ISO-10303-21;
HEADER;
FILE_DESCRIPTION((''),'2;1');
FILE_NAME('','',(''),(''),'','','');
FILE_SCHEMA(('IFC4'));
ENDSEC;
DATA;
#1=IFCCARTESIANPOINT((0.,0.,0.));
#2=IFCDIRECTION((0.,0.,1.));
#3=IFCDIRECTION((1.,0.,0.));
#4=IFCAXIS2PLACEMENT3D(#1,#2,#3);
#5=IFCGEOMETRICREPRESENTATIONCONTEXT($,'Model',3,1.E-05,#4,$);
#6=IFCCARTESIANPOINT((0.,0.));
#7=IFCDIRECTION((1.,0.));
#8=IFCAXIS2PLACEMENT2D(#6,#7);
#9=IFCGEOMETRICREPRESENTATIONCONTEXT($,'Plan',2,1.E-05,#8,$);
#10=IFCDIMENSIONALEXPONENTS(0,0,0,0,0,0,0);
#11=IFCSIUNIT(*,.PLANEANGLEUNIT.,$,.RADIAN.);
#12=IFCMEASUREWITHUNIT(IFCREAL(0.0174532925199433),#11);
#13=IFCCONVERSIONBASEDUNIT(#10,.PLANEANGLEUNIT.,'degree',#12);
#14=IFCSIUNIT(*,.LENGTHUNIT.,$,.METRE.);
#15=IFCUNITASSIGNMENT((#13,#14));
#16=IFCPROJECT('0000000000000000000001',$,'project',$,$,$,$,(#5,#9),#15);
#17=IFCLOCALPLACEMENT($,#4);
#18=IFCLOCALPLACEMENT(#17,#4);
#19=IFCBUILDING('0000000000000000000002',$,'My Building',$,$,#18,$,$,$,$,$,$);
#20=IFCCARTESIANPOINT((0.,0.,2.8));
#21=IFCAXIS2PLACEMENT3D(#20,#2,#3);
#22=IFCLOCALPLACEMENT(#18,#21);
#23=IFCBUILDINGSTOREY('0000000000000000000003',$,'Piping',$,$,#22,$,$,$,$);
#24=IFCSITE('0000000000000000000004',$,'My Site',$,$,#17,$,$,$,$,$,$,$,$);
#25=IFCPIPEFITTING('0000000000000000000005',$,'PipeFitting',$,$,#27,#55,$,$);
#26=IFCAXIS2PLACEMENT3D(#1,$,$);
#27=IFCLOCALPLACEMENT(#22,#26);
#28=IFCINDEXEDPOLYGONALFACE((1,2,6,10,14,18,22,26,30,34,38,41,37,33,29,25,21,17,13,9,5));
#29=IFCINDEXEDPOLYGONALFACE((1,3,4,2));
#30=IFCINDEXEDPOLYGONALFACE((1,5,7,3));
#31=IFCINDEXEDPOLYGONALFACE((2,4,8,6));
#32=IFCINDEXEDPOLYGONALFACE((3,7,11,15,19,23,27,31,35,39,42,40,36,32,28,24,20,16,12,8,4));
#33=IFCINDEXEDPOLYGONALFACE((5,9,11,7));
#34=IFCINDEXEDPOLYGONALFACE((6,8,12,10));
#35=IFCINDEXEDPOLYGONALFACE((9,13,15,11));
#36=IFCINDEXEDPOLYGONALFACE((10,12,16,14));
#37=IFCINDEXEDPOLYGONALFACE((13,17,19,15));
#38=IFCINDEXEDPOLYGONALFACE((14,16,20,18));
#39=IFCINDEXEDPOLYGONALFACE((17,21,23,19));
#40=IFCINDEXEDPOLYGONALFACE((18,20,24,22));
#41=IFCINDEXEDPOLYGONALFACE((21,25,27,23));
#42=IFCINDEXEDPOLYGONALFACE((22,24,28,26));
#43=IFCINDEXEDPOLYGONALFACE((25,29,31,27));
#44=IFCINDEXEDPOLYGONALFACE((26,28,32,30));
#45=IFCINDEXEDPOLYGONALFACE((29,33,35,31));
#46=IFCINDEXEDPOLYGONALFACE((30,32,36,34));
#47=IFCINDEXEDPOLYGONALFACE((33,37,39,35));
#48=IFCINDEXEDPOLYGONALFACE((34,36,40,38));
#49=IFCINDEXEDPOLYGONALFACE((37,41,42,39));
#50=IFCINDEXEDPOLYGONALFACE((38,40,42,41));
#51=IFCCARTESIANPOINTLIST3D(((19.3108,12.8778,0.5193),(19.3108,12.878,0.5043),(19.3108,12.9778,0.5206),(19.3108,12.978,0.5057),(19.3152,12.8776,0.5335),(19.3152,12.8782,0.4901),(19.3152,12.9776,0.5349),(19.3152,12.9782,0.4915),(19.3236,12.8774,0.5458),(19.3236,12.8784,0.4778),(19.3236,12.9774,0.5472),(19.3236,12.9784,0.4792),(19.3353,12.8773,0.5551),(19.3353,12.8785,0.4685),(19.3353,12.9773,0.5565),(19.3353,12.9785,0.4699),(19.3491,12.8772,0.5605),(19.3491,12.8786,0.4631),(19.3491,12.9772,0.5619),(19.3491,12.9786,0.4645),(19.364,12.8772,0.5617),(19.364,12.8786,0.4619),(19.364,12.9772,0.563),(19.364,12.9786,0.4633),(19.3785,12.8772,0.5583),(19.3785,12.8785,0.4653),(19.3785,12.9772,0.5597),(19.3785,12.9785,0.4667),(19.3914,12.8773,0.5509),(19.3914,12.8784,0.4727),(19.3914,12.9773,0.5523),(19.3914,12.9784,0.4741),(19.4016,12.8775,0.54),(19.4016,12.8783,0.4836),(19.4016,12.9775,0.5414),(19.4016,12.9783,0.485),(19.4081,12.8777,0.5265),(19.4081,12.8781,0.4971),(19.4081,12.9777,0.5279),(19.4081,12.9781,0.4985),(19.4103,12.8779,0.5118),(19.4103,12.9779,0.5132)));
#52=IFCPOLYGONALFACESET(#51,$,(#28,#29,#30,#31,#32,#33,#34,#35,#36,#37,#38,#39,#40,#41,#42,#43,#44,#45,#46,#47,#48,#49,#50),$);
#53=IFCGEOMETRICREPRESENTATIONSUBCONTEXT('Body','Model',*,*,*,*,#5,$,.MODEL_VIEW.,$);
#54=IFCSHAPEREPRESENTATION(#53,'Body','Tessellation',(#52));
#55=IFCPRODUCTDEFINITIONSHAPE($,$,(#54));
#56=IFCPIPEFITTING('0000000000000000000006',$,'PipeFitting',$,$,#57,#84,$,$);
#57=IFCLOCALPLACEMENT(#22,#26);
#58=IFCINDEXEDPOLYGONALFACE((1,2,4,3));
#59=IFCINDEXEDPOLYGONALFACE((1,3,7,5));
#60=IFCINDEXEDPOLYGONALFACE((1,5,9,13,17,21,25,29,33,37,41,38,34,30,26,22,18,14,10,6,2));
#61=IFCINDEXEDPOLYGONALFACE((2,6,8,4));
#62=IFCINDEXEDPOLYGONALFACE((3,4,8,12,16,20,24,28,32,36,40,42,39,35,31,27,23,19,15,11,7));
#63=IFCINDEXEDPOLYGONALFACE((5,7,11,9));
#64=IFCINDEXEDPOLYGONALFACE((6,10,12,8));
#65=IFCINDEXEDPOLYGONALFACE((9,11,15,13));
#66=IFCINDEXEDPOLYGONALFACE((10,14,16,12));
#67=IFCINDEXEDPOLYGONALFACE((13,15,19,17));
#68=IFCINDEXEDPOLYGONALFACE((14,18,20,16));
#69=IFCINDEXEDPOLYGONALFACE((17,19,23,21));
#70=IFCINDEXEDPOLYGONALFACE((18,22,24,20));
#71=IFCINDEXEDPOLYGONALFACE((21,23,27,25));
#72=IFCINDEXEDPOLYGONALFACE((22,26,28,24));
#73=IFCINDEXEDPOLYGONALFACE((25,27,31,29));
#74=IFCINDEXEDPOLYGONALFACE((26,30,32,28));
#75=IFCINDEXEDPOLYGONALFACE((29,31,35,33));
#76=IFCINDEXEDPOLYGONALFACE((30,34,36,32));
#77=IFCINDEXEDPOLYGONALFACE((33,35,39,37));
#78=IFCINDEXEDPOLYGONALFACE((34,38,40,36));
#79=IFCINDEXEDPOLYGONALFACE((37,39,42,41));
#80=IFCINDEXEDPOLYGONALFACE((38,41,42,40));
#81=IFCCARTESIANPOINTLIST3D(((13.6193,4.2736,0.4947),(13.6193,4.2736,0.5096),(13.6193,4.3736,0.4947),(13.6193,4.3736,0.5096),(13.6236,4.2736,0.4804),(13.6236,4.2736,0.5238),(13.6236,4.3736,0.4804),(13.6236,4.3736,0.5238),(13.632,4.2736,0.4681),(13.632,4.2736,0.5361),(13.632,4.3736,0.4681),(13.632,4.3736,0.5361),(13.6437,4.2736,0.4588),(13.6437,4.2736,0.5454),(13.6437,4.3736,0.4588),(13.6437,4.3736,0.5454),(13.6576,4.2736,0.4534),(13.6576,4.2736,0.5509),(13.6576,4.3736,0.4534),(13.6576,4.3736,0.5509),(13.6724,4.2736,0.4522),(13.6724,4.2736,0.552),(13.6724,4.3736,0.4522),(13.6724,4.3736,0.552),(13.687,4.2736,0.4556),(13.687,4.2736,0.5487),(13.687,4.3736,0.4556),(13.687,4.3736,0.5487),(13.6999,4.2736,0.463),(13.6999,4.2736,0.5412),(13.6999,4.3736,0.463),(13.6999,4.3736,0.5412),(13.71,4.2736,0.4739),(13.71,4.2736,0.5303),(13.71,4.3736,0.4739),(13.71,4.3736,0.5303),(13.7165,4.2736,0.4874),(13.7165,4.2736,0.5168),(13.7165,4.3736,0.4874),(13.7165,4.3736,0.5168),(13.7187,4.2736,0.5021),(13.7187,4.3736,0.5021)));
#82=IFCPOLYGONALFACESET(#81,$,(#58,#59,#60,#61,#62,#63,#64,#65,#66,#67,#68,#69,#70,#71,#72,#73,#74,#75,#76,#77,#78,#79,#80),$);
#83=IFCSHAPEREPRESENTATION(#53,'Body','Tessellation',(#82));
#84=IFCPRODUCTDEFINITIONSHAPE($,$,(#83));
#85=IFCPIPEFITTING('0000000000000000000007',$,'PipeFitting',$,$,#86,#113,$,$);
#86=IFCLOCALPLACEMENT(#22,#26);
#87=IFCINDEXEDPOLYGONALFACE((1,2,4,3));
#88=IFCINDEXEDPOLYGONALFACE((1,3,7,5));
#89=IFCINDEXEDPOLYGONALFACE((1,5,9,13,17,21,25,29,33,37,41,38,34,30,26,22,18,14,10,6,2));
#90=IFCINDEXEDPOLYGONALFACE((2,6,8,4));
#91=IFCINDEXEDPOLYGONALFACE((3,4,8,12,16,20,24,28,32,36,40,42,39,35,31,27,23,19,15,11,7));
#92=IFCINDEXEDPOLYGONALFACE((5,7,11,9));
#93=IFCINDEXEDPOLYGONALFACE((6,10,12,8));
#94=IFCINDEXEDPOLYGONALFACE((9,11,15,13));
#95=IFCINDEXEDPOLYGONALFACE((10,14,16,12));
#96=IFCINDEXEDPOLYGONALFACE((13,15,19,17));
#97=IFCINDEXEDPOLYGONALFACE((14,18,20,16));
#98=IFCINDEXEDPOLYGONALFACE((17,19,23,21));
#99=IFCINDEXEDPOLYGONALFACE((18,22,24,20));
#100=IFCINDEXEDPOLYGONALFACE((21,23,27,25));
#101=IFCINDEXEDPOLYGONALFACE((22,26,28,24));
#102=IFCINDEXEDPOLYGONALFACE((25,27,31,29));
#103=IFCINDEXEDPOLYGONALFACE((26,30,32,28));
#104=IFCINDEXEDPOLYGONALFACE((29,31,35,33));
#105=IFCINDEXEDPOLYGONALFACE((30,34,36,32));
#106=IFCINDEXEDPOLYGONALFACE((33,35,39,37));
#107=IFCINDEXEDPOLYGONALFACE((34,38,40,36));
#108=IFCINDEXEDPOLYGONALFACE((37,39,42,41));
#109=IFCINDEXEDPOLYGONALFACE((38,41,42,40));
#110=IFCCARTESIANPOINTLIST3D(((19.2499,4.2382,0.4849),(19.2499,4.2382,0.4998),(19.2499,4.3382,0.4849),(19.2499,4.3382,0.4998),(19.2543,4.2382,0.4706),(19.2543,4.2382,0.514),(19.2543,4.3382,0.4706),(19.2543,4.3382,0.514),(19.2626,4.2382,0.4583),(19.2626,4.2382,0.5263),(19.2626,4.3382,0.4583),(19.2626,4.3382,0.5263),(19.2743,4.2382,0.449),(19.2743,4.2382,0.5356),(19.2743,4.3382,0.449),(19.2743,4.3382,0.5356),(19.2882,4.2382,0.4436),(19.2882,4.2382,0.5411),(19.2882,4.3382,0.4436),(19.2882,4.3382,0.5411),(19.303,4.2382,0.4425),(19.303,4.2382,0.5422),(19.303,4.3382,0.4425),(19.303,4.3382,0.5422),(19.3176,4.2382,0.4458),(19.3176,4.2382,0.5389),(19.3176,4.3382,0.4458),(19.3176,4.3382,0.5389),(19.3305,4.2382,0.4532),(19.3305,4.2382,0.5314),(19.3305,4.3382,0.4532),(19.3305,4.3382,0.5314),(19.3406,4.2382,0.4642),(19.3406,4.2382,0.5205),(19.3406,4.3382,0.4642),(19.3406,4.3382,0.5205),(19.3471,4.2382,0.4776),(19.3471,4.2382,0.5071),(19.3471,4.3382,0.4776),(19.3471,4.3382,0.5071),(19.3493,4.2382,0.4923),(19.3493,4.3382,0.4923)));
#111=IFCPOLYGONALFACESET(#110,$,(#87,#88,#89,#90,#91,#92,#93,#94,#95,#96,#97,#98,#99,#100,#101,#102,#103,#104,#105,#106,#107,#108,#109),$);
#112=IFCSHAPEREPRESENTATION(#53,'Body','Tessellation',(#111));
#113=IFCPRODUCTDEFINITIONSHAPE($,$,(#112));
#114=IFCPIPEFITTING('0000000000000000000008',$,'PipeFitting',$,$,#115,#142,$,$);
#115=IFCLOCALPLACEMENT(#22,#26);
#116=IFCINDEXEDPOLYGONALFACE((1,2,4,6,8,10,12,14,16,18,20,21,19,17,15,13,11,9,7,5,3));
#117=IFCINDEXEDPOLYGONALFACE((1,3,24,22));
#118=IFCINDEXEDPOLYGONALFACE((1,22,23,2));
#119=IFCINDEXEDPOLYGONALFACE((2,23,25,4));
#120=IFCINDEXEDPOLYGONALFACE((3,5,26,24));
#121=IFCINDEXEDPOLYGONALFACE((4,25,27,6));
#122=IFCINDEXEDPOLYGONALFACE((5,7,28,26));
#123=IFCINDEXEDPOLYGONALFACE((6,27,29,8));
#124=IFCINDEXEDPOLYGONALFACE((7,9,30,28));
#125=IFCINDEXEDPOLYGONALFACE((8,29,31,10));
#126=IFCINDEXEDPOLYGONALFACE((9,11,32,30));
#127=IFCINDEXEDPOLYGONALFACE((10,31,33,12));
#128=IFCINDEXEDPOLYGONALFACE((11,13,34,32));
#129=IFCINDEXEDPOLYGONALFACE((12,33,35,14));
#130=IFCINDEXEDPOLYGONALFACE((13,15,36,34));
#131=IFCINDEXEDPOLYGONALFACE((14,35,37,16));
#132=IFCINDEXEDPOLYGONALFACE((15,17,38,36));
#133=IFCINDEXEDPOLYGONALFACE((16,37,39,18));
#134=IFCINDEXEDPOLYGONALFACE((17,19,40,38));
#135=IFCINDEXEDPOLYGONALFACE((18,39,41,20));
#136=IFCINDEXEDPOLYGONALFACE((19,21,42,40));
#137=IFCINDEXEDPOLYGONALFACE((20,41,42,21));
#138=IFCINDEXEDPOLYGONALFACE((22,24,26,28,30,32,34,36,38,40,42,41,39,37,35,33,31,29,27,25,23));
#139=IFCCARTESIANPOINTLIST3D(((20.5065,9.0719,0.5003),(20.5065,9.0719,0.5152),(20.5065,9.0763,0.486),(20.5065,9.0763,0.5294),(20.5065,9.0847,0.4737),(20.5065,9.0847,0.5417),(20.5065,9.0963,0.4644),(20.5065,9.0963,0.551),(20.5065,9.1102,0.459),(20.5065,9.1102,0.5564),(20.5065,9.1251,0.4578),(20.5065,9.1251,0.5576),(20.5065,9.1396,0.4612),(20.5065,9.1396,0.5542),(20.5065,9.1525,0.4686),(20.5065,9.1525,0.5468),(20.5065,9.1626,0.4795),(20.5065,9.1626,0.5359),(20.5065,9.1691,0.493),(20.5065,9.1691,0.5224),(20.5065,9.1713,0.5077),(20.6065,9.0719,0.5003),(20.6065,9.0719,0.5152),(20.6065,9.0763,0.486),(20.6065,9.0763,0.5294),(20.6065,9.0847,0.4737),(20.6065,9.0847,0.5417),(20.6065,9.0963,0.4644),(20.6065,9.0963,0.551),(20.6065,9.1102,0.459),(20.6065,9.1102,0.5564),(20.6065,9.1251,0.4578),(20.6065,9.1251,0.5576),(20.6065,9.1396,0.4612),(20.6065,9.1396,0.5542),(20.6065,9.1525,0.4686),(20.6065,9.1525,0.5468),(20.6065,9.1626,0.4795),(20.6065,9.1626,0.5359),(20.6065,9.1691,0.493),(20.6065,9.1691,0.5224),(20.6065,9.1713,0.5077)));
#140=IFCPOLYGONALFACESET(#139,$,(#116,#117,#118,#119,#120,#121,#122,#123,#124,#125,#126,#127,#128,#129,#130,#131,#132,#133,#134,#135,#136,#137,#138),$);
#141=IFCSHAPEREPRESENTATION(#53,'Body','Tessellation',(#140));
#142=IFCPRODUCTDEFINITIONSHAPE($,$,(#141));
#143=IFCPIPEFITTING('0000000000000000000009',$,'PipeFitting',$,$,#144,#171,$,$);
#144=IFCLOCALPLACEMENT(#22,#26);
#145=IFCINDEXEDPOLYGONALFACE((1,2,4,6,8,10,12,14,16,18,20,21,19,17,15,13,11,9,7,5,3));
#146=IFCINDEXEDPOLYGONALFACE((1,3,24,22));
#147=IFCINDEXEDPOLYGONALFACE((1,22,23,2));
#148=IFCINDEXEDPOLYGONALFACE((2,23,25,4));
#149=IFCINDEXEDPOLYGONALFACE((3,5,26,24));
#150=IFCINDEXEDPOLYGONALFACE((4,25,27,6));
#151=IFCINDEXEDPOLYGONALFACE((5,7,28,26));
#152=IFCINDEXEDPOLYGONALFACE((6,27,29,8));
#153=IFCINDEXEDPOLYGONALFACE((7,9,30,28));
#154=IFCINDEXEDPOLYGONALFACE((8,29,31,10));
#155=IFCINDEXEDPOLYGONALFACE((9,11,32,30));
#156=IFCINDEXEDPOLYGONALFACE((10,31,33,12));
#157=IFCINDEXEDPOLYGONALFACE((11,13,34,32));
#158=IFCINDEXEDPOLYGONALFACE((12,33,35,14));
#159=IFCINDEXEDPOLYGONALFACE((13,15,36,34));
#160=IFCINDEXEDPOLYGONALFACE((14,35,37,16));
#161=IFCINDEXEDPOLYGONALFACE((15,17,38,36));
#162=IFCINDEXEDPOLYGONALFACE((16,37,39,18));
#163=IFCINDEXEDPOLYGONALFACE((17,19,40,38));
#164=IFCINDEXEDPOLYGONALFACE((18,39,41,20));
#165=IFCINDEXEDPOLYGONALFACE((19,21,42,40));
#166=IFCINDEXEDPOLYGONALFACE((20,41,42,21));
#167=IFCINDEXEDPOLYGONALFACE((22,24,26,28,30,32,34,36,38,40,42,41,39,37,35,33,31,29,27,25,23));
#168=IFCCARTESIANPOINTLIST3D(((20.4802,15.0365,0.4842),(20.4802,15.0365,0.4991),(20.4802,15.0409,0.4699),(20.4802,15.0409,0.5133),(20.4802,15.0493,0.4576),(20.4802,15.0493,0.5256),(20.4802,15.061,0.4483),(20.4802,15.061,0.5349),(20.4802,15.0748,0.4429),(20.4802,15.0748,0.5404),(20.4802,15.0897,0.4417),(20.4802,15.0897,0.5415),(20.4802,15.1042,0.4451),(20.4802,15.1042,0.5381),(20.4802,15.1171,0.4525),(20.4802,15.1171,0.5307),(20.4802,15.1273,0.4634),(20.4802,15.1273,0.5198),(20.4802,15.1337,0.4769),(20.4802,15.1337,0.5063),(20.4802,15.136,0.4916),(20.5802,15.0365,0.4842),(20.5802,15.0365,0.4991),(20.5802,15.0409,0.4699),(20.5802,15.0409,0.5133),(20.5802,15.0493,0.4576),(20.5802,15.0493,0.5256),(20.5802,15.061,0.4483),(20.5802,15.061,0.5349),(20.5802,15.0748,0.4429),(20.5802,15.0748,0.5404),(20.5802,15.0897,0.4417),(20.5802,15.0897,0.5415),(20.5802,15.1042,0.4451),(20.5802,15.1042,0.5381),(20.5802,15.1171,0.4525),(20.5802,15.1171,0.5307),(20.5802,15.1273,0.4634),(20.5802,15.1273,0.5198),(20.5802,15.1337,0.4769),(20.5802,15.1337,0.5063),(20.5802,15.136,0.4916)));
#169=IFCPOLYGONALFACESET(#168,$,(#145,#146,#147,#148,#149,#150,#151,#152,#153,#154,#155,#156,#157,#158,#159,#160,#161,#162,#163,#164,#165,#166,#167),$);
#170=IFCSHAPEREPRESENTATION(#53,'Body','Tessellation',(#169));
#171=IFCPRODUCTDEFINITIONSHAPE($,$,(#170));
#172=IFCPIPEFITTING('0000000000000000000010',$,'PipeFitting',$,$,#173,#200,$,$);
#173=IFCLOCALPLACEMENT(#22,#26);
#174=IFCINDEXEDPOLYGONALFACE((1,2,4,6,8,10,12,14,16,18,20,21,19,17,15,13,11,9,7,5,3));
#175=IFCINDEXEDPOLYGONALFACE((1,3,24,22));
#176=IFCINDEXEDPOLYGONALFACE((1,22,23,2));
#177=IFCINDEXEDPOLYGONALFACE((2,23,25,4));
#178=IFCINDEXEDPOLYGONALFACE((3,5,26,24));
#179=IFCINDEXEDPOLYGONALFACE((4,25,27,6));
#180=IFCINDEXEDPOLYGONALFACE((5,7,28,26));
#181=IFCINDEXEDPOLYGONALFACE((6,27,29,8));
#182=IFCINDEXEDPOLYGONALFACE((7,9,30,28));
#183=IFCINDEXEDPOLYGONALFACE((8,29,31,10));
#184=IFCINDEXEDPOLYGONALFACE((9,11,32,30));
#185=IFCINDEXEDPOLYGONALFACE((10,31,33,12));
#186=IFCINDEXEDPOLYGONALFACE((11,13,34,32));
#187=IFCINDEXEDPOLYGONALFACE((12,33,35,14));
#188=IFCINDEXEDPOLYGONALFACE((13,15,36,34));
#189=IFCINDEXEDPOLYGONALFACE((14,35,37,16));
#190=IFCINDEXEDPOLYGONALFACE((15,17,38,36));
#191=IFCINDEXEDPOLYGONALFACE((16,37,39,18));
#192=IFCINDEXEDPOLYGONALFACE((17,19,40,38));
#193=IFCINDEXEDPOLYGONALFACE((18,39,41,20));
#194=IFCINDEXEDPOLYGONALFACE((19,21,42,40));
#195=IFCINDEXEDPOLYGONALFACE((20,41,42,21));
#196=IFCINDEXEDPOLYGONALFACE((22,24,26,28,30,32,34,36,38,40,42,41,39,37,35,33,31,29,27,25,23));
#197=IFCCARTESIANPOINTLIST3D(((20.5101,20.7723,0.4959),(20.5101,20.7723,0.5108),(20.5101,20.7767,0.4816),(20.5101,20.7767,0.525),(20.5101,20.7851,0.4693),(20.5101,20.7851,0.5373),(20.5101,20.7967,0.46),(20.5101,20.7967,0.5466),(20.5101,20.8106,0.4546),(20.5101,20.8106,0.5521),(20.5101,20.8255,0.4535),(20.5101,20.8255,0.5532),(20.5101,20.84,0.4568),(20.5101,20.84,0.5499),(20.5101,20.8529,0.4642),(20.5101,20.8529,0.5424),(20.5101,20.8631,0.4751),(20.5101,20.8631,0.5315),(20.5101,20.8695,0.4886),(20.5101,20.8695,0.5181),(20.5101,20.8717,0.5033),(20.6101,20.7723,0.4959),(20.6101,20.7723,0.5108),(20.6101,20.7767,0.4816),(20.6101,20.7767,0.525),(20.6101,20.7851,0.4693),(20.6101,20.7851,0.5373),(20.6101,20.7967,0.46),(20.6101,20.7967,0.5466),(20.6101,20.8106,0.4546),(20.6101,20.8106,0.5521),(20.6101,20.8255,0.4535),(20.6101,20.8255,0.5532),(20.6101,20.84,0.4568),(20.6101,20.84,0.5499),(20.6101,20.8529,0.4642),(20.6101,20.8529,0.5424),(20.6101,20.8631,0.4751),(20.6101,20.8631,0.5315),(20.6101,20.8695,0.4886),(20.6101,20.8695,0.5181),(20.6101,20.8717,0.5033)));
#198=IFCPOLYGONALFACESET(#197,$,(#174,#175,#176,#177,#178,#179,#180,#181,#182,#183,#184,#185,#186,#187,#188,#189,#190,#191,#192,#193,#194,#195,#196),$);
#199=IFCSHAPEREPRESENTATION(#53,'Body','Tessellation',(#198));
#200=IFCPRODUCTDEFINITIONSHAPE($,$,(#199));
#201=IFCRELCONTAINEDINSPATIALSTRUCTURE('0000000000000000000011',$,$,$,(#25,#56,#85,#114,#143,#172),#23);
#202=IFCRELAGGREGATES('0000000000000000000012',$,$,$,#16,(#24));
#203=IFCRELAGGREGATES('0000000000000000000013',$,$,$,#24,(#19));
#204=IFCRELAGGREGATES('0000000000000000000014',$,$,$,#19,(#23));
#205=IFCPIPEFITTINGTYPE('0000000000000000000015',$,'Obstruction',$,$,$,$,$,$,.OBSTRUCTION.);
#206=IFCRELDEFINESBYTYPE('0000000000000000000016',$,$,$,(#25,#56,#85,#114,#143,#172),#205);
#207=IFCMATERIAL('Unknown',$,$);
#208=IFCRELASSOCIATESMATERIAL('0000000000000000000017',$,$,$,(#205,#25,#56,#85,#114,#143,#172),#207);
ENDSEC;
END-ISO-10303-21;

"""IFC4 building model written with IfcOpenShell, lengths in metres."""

from ifc_helpers import new_model, entity, si_unit, converted_unit, frame, origin_with_axes, origin_2d_with_axis, place, context, subcontext, project, spatial, circle, extrude, material, material_profile, profile_set, profile_usage, type_object, element, save


model = new_model("IFC4")

# Units and contexts
model_context = context("Model", 3, precision=1e-05, world=origin_with_axes())
plan_context = context("Plan", 2, precision=1e-05, world=origin_2d_with_axis())
body_context = subcontext(model_context, "Body", "Model", "MODEL_VIEW")
ifc_project = project(units=[converted_unit("PLANEANGLEUNIT", "degree", entity("IfcReal", 0.0174532925199433), si_unit("PLANEANGLEUNIT", "RADIAN"), dimensions=[0, 0, 0, 0, 0, 0, 0]), si_unit("LENGTHUNIT", "METRE")], contexts=[model_context, plan_context])

# Site, building, storey
site_placement = place(None, origin_with_axes())
site = spatial("IfcSite", under=ifc_project, at=site_placement, Name="My Site")
building_placement = place(site_placement, origin_with_axes())
building = spatial("IfcBuilding", under=site, at=building_placement, Name="My Building")
storey_placement = place(building_placement, frame((0.0, 0.0, 2.8), z_axis=(0.0, 0.0, 1.0), x_axis=(1.0, 0.0, 0.0)))
storey = spatial("IfcBuildingStorey", under=building, at=storey_placement, Name="Piping")

# Shared definitions
ifc_material = material(Name="Unknown")

# Pipe fittings
ifc_material_profile_1 = material_profile(ifc_material, circle(Radius=0.05))
ifc_profile_set_1 = profile_set([ifc_material_profile_1])
ifc_profile_usage_1 = profile_usage(ifc_profile_set_1, cardinal=5)
pipe_fitting_type_1 = type_object("IfcPipeFittingType", Name="Obstruction", PredefinedType="OBSTRUCTION", material=ifc_profile_set_1)
pipe_fitting_1_placement = place(storey_placement, frame((19.3603, 12.9779, 0.5132), z_axis=(0.0, -0.999903, -0.013947), x_axis=(1.0, 0.0, 0.0)))
element("IfcPipeFitting", 1, at=pipe_fitting_1_placement, inside=storey, type_object=pipe_fitting_type_1, material=ifc_profile_usage_1, Name="PipeFitting", context=body_context, shape_type="SweptSolid", body=[
    extrude(circle(Radius=0.05), origin_with_axes(), (0.0, 0.0, 1.0), 0.1),
])
ifc_profile_usage_2 = profile_usage(ifc_profile_set_1, cardinal=5)
pipe_fitting_2_placement = place(storey_placement, frame((13.6687, 4.3736, 0.5021), z_axis=(0.0, -1.0, 0.0), x_axis=(1.0, 0.0, 0.0)))
element("IfcPipeFitting", 2, at=pipe_fitting_2_placement, inside=storey, type_object=pipe_fitting_type_1, material=ifc_profile_usage_2, Name="PipeFitting", context=body_context, shape_type="SweptSolid", body=[
    extrude(circle(Radius=0.05), origin_with_axes(), (0.0, 0.0, 1.0), 0.1),
])
ifc_profile_usage_3 = profile_usage(ifc_profile_set_1, cardinal=5)
pipe_fitting_3_placement = place(storey_placement, frame((19.2993, 4.3382, 0.4923), z_axis=(0.0, -1.0, 0.0), x_axis=(1.0, 0.0, 0.0)))
element("IfcPipeFitting", 3, at=pipe_fitting_3_placement, inside=storey, type_object=pipe_fitting_type_1, material=ifc_profile_usage_3, Name="PipeFitting", context=body_context, shape_type="SweptSolid", body=[
    extrude(circle(Radius=0.05), origin_with_axes(), (0.0, 0.0, 1.0), 0.1),
])
ifc_profile_usage_4 = profile_usage(ifc_profile_set_1, cardinal=5)
pipe_fitting_4_placement = place(storey_placement, frame((20.5065, 9.1213, 0.5077), z_axis=(1.0, 0.0, 0.0), x_axis=(0.0, 1.0, 0.0)))
element("IfcPipeFitting", 4, at=pipe_fitting_4_placement, inside=storey, type_object=pipe_fitting_type_1, material=ifc_profile_usage_4, Name="PipeFitting", context=body_context, shape_type="SweptSolid", body=[
    extrude(circle(Radius=0.05), origin_with_axes(), (0.0, 0.0, 1.0), 0.1),
])
ifc_profile_usage_5 = profile_usage(ifc_profile_set_1, cardinal=5)
pipe_fitting_5_placement = place(storey_placement, frame((20.4802, 15.086, 0.4916), z_axis=(1.0, 0.0, 0.0), x_axis=(0.0, 1.0, 0.0)))
element("IfcPipeFitting", 5, at=pipe_fitting_5_placement, inside=storey, type_object=pipe_fitting_type_1, material=ifc_profile_usage_5, Name="PipeFitting", context=body_context, shape_type="SweptSolid", body=[
    extrude(circle(Radius=0.05), origin_with_axes(), (0.0, 0.0, 1.0), 0.1),
])
ifc_profile_usage_6 = profile_usage(ifc_profile_set_1, cardinal=5)
pipe_fitting_6_placement = place(storey_placement, frame((20.5101, 20.8217, 0.5033), z_axis=(1.0, 0.0, 0.0), x_axis=(0.0, 1.0, 0.0)))
element("IfcPipeFitting", 6, at=pipe_fitting_6_placement, inside=storey, type_object=pipe_fitting_type_1, material=ifc_profile_usage_6, Name="PipeFitting", context=body_context, shape_type="SweptSolid", body=[
    extrude(circle(Radius=0.05), origin_with_axes(), (0.0, 0.0, 1.0), 0.1),
])

save(model, "model.ifc")
